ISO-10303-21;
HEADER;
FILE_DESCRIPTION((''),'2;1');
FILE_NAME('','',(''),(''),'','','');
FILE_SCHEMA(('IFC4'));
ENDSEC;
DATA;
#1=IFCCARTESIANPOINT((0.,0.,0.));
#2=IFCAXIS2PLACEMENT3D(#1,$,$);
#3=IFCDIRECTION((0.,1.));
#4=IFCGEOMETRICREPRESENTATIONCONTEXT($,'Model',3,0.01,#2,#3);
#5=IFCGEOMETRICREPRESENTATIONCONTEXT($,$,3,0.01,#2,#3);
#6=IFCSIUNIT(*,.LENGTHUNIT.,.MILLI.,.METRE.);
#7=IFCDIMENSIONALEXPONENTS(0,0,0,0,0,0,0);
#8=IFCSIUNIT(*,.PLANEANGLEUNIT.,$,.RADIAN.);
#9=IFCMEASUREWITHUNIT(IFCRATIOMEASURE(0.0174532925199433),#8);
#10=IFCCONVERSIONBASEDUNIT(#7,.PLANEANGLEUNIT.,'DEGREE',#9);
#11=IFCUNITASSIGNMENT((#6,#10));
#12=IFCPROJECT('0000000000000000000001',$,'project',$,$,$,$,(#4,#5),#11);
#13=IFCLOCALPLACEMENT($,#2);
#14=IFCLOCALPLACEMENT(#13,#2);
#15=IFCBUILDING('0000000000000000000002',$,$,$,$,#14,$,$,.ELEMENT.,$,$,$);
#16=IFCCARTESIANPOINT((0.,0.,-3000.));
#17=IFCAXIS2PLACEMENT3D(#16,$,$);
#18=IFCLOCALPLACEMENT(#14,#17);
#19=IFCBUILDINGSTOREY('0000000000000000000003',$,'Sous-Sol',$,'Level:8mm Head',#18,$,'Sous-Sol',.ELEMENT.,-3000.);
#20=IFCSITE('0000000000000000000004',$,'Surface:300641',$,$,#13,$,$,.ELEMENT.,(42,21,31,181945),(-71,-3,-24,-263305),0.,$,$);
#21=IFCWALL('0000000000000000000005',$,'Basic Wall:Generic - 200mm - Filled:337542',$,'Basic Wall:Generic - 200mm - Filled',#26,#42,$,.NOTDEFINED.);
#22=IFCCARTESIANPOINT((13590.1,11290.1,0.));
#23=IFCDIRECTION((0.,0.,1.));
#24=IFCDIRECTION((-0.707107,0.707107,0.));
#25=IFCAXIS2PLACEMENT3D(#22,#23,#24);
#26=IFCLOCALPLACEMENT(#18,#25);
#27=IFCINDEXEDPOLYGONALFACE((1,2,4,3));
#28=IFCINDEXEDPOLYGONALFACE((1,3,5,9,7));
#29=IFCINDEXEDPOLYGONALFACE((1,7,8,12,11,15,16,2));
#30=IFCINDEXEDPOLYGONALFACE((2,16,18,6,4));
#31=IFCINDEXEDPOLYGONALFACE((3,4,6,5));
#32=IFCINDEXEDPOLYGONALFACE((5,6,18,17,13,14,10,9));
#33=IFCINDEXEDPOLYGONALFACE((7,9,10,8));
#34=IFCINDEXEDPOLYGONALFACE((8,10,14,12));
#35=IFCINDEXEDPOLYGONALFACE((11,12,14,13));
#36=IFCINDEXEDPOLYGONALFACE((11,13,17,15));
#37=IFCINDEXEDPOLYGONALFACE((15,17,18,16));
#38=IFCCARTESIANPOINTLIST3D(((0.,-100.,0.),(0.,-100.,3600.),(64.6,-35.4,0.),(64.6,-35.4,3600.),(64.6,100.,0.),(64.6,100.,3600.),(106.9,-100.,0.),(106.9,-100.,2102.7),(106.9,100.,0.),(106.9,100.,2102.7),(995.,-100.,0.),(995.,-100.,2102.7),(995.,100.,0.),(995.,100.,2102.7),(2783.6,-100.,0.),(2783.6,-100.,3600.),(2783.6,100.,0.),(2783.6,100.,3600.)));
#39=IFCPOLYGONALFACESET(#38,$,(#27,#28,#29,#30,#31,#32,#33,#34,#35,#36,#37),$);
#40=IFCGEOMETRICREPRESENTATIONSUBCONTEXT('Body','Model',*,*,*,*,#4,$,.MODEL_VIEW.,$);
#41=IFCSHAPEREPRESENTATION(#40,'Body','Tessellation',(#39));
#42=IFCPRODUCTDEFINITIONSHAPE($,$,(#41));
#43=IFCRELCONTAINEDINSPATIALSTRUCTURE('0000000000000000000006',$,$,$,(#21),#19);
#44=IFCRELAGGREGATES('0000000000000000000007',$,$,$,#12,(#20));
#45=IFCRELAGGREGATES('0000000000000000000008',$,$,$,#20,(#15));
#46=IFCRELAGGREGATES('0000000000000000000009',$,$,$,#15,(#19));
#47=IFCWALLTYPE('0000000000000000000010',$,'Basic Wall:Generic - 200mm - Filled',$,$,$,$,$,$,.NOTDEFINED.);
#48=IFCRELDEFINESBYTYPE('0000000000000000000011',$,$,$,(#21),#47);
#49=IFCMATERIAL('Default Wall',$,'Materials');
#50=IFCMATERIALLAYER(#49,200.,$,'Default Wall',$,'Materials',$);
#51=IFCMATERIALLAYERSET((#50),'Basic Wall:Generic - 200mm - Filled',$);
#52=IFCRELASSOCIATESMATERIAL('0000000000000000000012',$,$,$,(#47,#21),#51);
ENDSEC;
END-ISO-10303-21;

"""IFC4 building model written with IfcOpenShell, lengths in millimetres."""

from ifc_helpers import new_model, entity, si_unit, converted_unit, direction, frame, origin, origin_2d_with_axis, place, context, subcontext, project, spatial, polyline, rectangle, outline, extrude, material, layer, layer_set, layer_usage, type_object, element, save


model = new_model("IFC4")

# Units and contexts
model_context = context("Model", 3, precision=0.01, world=origin(), true_north=direction((0.0, 1.0)))
context_of_model = context(None, 3, precision=0.01, world=origin(), true_north=direction((0.0, 1.0)))
body_context = subcontext(model_context, "Body", "Model", "MODEL_VIEW")
ifc_project = project(units=[si_unit("LENGTHUNIT", "METRE", prefix="MILLI"), converted_unit("PLANEANGLEUNIT", "DEGREE", entity("IfcRatioMeasure", 0.0174532925199433), si_unit("PLANEANGLEUNIT", "RADIAN"), dimensions=[0, 0, 0, 0, 0, 0, 0])], contexts=[model_context, context_of_model])

# Site, building, storey
site_placement = place(None, origin())
site = spatial("IfcSite", under=ifc_project, at=site_placement, Name="Surface:300641", CompositionType="ELEMENT", RefLatitude=(42, 21, 31, 181945), RefLongitude=(-71, -3, -24, -263305), RefElevation=0.0)
building_placement = place(site_placement, origin())
building = spatial("IfcBuilding", under=site, at=building_placement, CompositionType="ELEMENT")
storey_placement = place(building_placement, frame((0.0, 0.0, -3000.0)))
storey = spatial("IfcBuildingStorey", under=building, at=storey_placement, Name="Sous-Sol", ObjectType="Level:8mm Head", LongName="Sous-Sol", CompositionType="ELEMENT", Elevation=-3000.0)

# Shared definitions
ifc_material_1 = material(Name="Default Wall", Category="Materials")

# Wall, opening
ifc_layer_1 = layer(ifc_material_1, 200.0, Name="Default Wall", Category="Materials")
ifc_layer_set_1 = layer_set([ifc_layer_1], Name="Basic Wall:Generic - 200mm - Filled")
ifc_layer_usage_1 = layer_usage(ifc_layer_set_1, "AXIS2", "NEGATIVE", 100.0)
wall_type_1 = type_object("IfcWallType", Name="Basic Wall:Generic - 200mm - Filled", PredefinedType="NOTDEFINED", material=ifc_layer_set_1)
wall_1_placement = place(storey_placement, frame((13590.1, 11290.1, 0.0), z_axis=(0.0, 0.0, 1.0), x_axis=(-0.707107, 0.707107, 0.0)))
wall_1 = element("IfcWall", 1, at=wall_1_placement, inside=storey, type_object=wall_type_1, material=ifc_layer_usage_1, Name="Basic Wall:Generic - 200mm - Filled:337542", ObjectType="Basic Wall:Generic - 200mm - Filled", PredefinedType="NOTDEFINED", context=body_context, shape_type="SweptSolid", body=[
    extrude(outline(polyline([(0.0, -100.0), (2783.6, -100.0), (2783.6, 100.0), (64.6, 100.0), (64.6, -35.4), (0.0, -100.0)])), origin(), (0.0, 0.0, 1.0), 3600.0),
])
opening_1_placement = place(wall_1_placement, frame((550.9, 544.0, -28.3)))
element("IfcOpeningElement", 2, at=opening_1_placement, cuts=wall_1, ObjectType="Opening", PredefinedType="OPENING", context=body_context, shape_type="SweptSolid", body=[
    extrude(rectangle(XDim=2131.0, YDim=888.1, at=origin_2d_with_axis()), frame((0.0, -644.0, 1065.5), z_axis=(0.0, 1.0, 0.0), x_axis=(0.0, 0.0, -1.0)), (0.0, 0.0, 1.0), 200.0),
])

save(model, "model.ifc")
